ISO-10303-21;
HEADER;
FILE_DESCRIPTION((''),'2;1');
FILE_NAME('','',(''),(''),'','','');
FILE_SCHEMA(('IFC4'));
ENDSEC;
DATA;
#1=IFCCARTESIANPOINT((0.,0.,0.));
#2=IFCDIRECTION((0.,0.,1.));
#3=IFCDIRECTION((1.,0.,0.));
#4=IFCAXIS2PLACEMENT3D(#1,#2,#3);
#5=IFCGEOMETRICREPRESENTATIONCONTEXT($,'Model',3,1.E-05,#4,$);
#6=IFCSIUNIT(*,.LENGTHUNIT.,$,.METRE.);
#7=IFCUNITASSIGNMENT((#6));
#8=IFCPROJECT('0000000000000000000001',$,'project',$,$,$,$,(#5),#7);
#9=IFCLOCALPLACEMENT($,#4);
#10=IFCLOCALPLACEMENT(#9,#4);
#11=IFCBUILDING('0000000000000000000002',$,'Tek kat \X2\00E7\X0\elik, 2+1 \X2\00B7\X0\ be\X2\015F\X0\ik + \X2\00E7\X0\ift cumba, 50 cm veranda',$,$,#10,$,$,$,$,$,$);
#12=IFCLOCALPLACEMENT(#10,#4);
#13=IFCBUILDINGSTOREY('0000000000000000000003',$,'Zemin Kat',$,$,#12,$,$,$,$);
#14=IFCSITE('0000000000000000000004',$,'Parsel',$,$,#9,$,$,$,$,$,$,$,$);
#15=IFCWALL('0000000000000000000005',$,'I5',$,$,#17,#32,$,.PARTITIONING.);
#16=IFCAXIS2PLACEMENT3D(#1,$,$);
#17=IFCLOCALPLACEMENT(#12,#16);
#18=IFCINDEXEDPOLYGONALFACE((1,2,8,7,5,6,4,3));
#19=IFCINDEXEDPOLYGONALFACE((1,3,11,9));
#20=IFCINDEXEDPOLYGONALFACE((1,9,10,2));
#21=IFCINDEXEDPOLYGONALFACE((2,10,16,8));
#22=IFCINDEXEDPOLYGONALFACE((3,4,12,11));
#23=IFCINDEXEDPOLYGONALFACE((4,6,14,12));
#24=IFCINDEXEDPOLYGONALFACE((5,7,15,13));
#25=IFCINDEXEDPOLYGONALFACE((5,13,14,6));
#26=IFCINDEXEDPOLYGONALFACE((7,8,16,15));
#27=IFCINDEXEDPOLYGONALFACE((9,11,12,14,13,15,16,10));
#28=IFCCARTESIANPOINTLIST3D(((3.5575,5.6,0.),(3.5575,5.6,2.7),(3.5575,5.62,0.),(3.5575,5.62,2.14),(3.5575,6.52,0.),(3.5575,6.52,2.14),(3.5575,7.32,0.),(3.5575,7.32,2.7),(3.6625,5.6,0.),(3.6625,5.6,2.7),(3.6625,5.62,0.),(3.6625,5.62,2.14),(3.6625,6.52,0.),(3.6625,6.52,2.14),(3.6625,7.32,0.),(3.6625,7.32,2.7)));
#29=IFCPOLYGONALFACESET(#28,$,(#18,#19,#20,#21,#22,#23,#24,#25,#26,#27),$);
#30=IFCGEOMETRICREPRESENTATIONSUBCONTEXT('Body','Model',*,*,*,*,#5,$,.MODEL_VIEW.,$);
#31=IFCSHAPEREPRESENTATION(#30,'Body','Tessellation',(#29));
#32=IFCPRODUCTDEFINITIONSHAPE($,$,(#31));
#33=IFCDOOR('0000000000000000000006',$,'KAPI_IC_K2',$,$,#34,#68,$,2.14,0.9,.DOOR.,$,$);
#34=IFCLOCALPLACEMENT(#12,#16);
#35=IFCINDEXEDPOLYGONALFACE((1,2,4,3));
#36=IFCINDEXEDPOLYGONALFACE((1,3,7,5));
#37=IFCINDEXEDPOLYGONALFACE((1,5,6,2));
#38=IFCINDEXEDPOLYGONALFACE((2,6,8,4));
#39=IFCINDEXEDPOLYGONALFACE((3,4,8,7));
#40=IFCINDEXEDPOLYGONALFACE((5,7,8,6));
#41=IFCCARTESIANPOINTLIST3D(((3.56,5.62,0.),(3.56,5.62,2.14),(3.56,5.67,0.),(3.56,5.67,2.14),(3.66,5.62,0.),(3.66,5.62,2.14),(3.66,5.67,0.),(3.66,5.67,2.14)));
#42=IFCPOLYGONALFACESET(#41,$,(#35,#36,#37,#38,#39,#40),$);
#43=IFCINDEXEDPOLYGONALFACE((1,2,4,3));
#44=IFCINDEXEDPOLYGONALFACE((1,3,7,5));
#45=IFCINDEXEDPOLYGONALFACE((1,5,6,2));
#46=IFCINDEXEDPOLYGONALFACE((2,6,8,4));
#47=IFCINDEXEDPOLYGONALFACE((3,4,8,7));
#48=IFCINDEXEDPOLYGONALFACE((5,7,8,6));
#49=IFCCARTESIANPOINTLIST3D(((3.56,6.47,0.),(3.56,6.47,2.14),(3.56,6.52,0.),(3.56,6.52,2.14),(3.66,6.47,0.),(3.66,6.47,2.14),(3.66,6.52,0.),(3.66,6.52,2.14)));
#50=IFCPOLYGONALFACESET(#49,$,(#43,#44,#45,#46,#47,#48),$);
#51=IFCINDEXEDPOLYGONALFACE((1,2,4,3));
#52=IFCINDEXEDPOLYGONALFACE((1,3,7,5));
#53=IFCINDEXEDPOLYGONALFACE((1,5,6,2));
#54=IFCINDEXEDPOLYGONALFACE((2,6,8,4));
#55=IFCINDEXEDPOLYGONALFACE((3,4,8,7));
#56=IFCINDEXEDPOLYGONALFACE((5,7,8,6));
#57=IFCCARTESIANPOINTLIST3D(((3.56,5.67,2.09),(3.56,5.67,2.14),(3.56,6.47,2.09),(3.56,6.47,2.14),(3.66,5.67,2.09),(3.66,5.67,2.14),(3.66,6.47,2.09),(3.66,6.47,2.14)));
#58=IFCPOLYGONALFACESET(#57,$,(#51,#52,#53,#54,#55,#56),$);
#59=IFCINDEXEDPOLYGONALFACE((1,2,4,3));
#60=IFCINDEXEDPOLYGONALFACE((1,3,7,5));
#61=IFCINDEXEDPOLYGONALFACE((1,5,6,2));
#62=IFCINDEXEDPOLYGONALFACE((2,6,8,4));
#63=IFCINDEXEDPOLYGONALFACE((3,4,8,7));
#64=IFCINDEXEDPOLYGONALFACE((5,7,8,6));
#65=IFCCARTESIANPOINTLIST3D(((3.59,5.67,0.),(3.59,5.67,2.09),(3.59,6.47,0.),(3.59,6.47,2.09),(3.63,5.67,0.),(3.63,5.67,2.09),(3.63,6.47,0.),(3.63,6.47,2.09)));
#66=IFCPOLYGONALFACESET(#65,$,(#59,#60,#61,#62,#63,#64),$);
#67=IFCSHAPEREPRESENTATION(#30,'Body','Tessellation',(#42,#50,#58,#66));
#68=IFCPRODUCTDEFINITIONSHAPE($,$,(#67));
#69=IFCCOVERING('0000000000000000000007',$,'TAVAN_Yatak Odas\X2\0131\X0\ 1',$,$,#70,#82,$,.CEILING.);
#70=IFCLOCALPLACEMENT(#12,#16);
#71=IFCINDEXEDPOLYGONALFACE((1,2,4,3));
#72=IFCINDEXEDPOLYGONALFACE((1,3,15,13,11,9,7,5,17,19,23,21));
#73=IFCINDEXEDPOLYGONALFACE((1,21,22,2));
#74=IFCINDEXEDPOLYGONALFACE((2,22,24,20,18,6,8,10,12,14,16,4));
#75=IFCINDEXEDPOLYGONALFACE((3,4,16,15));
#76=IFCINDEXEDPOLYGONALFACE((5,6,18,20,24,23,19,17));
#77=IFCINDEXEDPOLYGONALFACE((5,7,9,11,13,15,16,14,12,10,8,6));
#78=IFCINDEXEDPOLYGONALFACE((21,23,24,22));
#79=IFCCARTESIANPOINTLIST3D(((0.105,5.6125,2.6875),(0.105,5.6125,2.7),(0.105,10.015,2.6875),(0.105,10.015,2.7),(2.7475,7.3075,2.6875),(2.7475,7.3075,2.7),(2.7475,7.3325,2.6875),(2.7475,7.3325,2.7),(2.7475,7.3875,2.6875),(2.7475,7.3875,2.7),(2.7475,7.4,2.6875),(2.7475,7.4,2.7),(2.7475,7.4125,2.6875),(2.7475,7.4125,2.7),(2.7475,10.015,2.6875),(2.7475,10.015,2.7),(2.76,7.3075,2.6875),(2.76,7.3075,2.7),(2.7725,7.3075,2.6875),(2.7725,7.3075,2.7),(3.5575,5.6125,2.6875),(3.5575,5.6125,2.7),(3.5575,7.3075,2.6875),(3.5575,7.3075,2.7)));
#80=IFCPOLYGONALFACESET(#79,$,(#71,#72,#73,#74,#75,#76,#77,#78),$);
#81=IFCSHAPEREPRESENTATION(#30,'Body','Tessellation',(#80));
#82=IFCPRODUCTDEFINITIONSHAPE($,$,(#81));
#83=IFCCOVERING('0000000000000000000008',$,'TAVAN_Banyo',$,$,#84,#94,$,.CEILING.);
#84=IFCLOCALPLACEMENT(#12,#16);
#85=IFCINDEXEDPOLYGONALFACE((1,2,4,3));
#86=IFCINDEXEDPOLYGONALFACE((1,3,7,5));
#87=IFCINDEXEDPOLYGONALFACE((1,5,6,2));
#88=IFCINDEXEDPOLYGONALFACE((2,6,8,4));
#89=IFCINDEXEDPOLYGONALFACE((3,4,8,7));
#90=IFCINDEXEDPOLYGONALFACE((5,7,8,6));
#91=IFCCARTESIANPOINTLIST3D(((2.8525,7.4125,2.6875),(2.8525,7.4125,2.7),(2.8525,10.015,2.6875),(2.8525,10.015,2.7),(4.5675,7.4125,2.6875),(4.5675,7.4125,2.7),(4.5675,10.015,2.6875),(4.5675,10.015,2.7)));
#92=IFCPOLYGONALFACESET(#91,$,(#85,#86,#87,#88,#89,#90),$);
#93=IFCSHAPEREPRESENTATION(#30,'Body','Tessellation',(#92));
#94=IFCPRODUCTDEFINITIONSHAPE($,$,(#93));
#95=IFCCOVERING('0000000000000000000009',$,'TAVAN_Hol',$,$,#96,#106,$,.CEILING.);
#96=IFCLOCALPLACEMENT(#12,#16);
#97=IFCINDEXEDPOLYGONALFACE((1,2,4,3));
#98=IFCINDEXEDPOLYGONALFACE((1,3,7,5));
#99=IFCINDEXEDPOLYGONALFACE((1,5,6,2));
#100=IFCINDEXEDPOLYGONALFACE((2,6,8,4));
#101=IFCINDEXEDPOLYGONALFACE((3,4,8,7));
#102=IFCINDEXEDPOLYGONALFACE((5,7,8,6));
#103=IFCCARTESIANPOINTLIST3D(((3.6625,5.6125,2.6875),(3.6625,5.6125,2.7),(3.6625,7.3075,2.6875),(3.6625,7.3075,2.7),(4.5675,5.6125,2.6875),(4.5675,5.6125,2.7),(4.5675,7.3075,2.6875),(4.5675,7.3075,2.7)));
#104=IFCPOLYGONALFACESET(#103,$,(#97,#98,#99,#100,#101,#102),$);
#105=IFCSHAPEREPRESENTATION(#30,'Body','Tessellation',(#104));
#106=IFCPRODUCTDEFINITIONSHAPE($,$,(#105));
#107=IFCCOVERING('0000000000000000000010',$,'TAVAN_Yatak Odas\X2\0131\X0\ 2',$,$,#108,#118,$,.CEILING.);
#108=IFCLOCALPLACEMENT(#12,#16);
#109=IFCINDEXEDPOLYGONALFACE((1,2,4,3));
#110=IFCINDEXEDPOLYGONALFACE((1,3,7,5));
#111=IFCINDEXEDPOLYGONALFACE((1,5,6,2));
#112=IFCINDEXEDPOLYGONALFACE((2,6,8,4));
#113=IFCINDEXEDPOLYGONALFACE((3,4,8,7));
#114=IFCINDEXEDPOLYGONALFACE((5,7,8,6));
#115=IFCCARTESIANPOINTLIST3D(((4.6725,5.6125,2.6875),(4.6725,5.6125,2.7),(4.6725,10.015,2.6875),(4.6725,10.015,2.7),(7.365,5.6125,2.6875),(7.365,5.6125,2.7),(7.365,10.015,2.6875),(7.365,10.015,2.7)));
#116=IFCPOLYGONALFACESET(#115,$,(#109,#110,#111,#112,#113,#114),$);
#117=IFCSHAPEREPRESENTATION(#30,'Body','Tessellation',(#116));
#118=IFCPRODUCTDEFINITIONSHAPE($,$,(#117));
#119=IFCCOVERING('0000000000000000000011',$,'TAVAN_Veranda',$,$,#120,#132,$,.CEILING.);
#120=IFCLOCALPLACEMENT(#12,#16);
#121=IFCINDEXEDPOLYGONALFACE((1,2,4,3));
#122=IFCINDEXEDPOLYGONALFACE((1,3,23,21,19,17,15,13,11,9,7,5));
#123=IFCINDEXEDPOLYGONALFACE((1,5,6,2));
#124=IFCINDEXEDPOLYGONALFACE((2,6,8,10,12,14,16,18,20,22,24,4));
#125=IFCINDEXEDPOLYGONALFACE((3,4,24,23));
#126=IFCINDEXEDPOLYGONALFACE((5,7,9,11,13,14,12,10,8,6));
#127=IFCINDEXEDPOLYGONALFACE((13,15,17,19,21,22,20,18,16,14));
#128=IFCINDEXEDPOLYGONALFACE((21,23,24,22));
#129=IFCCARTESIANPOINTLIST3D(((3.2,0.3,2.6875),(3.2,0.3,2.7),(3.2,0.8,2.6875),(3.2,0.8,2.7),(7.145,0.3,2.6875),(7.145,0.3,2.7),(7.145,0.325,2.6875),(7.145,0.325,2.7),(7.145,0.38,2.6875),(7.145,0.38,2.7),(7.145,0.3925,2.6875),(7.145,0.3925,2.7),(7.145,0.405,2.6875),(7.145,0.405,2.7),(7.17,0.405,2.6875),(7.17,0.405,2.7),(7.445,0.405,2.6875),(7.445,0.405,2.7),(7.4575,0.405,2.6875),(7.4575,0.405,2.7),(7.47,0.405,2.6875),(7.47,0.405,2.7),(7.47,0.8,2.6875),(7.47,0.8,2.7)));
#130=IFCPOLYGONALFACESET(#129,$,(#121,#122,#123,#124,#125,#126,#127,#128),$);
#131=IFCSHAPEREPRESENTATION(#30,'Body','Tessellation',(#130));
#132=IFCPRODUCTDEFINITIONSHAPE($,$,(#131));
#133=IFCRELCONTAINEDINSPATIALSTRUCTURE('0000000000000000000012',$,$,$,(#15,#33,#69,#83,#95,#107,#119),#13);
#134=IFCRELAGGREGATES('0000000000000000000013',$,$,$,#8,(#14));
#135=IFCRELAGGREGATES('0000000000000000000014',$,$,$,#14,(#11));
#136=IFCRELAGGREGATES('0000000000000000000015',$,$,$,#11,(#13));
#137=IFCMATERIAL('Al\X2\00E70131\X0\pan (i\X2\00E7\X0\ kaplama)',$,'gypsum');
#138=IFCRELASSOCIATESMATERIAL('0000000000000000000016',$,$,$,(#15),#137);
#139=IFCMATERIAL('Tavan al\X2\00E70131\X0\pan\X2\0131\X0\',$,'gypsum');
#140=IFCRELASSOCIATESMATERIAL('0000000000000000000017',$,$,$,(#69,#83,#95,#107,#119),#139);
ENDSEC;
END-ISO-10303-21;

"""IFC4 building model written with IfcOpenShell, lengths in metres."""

from ifc_helpers import new_model, si_unit, frame, origin_with_axes, place, context, subcontext, project, spatial, line, indexed_curve, outline, extrude, material, element, fill, save


model = new_model("IFC4")

# Units and contexts
model_context = context("Model", 3, precision=1e-05, world=origin_with_axes())
body_context = subcontext(model_context, "Body", "Model", "MODEL_VIEW")
ifc_project = project(units=[si_unit("LENGTHUNIT", "METRE")], contexts=[model_context])

# Site, building, storey
site_placement = place(None, origin_with_axes())
site = spatial("IfcSite", under=ifc_project, at=site_placement, Name="Parsel")
building_placement = place(site_placement, origin_with_axes())
building = spatial("IfcBuilding", under=site, at=building_placement, Name="Tek kat çelik, 2+1 · beşik + çift cumba, 50 cm veranda")
storey_placement = place(building_placement, origin_with_axes())
storey = spatial("IfcBuildingStorey", under=building, at=storey_placement, Name="Zemin Kat")

# Wall, opening, door
ifc_material_1 = material(Name="Alçıpan (iç kaplama)", Category="gypsum")
wall_placement = place(storey_placement, origin_with_axes())
wall = element("IfcWall", 1, at=wall_placement, inside=storey, material=ifc_material_1, Name="I5", PredefinedType="PARTITIONING", context=body_context, shape_type="SweptSolid", body=[
    extrude(outline(indexed_curve([(0.0, 0.0), (0.105, 0.0), (0.105, 1.72), (0.0, 1.72)], segments=[line(1, 2, 3, 4, 1)])), frame((3.5575, 5.6, 0.0), z_axis=(0.0, 0.0, 1.0), x_axis=(1.0, 0.0, 0.0)), (0.0, 0.0, 1.0), 2.7),
])
opening_placement = place(wall_placement, origin_with_axes())
opening = element("IfcOpeningElement", 2, at=opening_placement, cuts=wall, PredefinedType="OPENING", context=body_context, shape_type="SweptSolid", body=[
    extrude(outline(indexed_curve([(0.0, 0.0), (0.145, 0.0), (0.145, 0.9), (0.0, 0.9)], segments=[line(1, 2, 3, 4, 1)])), frame((3.5375, 5.62, 0.0), z_axis=(0.0, 0.0, 1.0), x_axis=(1.0, 0.0, 0.0)), (0.0, 0.0, 1.0), 2.14),
])
door_placement = place(storey_placement, origin_with_axes())
door = element("IfcDoor", 3, at=door_placement, inside=storey, Name="KAPI_IC_K2", OverallHeight=2.14, OverallWidth=0.9, PredefinedType="DOOR", context=body_context, shape_type="SweptSolid", body=[
    extrude(outline(indexed_curve([(0.0, 0.0), (0.1, 0.0), (0.1, 0.05), (0.0, 0.05)], segments=[line(1, 2, 3, 4, 1)])), frame((3.56, 5.62, 0.0), z_axis=(0.0, 0.0, 1.0), x_axis=(1.0, 0.0, 0.0)), (0.0, 0.0, 1.0), 2.14),
    extrude(outline(indexed_curve([(0.0, 0.0), (0.1, 0.0), (0.1, 0.05), (0.0, 0.05)], segments=[line(1, 2, 3, 4, 1)])), frame((3.56, 6.47, 0.0), z_axis=(0.0, 0.0, 1.0), x_axis=(1.0, 0.0, 0.0)), (0.0, 0.0, 1.0), 2.14),
    extrude(outline(indexed_curve([(0.0, 0.0), (0.1, 0.0), (0.1, 0.8), (0.0, 0.8)], segments=[line(1, 2, 3, 4, 1)])), frame((3.56, 5.67, 2.09), z_axis=(0.0, 0.0, 1.0), x_axis=(1.0, 0.0, 0.0)), (0.0, 0.0, 1.0), 0.05),
    extrude(outline(indexed_curve([(0.0, 0.0), (0.04, 0.0), (0.04, 0.8), (0.0, 0.8)], segments=[line(1, 2, 3, 4, 1)])), frame((3.59, 5.67, 0.0), z_axis=(0.0, 0.0, 1.0), x_axis=(1.0, 0.0, 0.0)), (0.0, 0.0, 1.0), 2.09),
])
fill(opening, door)

# Coverings
ifc_material_2 = material(Name="Tavan alçıpanı", Category="gypsum")
covering_1_placement = place(storey_placement, origin_with_axes())
element("IfcCovering", 4, at=covering_1_placement, inside=storey, material=ifc_material_2, Name="TAVAN_Yatak Odası 1", PredefinedType="CEILING", context=body_context, shape_type="SweptSolid", body=[
    extrude(outline(indexed_curve([(2.7475, 10.015), (2.7475, 7.4125), (2.7475, 7.4), (2.7475, 7.3875), (2.7475, 7.3325), (2.7475, 7.3075), (2.76, 7.3075), (2.7725, 7.3075), (3.5575, 7.3075), (3.5575, 5.6125), (0.105, 5.6125), (0.105, 10.015)], segments=[line(1, 2, 3, 4, 5, 6, 7, 8, 9, 10, 11, 12, 1)])), frame((0.0, 0.0, 2.6875), z_axis=(0.0, 0.0, 1.0), x_axis=(1.0, 0.0, 0.0)), (0.0, 0.0, 1.0), 0.0125),
])
covering_2_placement = place(storey_placement, origin_with_axes())
element("IfcCovering", 5, at=covering_2_placement, inside=storey, material=ifc_material_2, Name="TAVAN_Banyo", PredefinedType="CEILING", context=body_context, shape_type="SweptSolid", body=[
    extrude(outline(indexed_curve([(2.8525, 10.015), (4.5675, 10.015), (4.5675, 7.4125), (2.8525, 7.4125)], segments=[line(1, 2, 3, 4, 1)])), frame((0.0, 0.0, 2.6875), z_axis=(0.0, 0.0, 1.0), x_axis=(1.0, 0.0, 0.0)), (0.0, 0.0, 1.0), 0.0125),
])
covering_3_placement = place(storey_placement, origin_with_axes())
element("IfcCovering", 6, at=covering_3_placement, inside=storey, material=ifc_material_2, Name="TAVAN_Hol", PredefinedType="CEILING", context=body_context, shape_type="SweptSolid", body=[
    extrude(outline(indexed_curve([(3.6625, 7.3075), (4.5675, 7.3075), (4.5675, 5.6125), (3.6625, 5.6125)], segments=[line(1, 2, 3, 4, 1)])), frame((0.0, 0.0, 2.6875), z_axis=(0.0, 0.0, 1.0), x_axis=(1.0, 0.0, 0.0)), (0.0, 0.0, 1.0), 0.0125),
])
covering_4_placement = place(storey_placement, origin_with_axes())
element("IfcCovering", 7, at=covering_4_placement, inside=storey, material=ifc_material_2, Name="TAVAN_Yatak Odası 2", PredefinedType="CEILING", context=body_context, shape_type="SweptSolid", body=[
    extrude(outline(indexed_curve([(4.6725, 10.015), (7.365, 10.015), (7.365, 5.6125), (4.6725, 5.6125)], segments=[line(1, 2, 3, 4, 1)])), frame((0.0, 0.0, 2.6875), z_axis=(0.0, 0.0, 1.0), x_axis=(1.0, 0.0, 0.0)), (0.0, 0.0, 1.0), 0.0125),
])
covering_5_placement = place(storey_placement, origin_with_axes())
element("IfcCovering", 8, at=covering_5_placement, inside=storey, material=ifc_material_2, Name="TAVAN_Veranda", PredefinedType="CEILING", context=body_context, shape_type="SweptSolid", body=[
    extrude(outline(indexed_curve([(7.47, 0.8), (7.47, 0.405), (7.4575, 0.405), (7.445, 0.405), (7.17, 0.405), (7.145, 0.405), (7.145, 0.3925), (7.145, 0.38), (7.145, 0.325), (7.145, 0.3), (3.2, 0.3), (3.2, 0.8)], segments=[line(1, 2, 3, 4, 5, 6, 7, 8, 9, 10, 11, 12, 1)])), frame((0.0, 0.0, 2.6875), z_axis=(0.0, 0.0, 1.0), x_axis=(1.0, 0.0, 0.0)), (0.0, 0.0, 1.0), 0.0125),
])

save(model, "model.ifc")
